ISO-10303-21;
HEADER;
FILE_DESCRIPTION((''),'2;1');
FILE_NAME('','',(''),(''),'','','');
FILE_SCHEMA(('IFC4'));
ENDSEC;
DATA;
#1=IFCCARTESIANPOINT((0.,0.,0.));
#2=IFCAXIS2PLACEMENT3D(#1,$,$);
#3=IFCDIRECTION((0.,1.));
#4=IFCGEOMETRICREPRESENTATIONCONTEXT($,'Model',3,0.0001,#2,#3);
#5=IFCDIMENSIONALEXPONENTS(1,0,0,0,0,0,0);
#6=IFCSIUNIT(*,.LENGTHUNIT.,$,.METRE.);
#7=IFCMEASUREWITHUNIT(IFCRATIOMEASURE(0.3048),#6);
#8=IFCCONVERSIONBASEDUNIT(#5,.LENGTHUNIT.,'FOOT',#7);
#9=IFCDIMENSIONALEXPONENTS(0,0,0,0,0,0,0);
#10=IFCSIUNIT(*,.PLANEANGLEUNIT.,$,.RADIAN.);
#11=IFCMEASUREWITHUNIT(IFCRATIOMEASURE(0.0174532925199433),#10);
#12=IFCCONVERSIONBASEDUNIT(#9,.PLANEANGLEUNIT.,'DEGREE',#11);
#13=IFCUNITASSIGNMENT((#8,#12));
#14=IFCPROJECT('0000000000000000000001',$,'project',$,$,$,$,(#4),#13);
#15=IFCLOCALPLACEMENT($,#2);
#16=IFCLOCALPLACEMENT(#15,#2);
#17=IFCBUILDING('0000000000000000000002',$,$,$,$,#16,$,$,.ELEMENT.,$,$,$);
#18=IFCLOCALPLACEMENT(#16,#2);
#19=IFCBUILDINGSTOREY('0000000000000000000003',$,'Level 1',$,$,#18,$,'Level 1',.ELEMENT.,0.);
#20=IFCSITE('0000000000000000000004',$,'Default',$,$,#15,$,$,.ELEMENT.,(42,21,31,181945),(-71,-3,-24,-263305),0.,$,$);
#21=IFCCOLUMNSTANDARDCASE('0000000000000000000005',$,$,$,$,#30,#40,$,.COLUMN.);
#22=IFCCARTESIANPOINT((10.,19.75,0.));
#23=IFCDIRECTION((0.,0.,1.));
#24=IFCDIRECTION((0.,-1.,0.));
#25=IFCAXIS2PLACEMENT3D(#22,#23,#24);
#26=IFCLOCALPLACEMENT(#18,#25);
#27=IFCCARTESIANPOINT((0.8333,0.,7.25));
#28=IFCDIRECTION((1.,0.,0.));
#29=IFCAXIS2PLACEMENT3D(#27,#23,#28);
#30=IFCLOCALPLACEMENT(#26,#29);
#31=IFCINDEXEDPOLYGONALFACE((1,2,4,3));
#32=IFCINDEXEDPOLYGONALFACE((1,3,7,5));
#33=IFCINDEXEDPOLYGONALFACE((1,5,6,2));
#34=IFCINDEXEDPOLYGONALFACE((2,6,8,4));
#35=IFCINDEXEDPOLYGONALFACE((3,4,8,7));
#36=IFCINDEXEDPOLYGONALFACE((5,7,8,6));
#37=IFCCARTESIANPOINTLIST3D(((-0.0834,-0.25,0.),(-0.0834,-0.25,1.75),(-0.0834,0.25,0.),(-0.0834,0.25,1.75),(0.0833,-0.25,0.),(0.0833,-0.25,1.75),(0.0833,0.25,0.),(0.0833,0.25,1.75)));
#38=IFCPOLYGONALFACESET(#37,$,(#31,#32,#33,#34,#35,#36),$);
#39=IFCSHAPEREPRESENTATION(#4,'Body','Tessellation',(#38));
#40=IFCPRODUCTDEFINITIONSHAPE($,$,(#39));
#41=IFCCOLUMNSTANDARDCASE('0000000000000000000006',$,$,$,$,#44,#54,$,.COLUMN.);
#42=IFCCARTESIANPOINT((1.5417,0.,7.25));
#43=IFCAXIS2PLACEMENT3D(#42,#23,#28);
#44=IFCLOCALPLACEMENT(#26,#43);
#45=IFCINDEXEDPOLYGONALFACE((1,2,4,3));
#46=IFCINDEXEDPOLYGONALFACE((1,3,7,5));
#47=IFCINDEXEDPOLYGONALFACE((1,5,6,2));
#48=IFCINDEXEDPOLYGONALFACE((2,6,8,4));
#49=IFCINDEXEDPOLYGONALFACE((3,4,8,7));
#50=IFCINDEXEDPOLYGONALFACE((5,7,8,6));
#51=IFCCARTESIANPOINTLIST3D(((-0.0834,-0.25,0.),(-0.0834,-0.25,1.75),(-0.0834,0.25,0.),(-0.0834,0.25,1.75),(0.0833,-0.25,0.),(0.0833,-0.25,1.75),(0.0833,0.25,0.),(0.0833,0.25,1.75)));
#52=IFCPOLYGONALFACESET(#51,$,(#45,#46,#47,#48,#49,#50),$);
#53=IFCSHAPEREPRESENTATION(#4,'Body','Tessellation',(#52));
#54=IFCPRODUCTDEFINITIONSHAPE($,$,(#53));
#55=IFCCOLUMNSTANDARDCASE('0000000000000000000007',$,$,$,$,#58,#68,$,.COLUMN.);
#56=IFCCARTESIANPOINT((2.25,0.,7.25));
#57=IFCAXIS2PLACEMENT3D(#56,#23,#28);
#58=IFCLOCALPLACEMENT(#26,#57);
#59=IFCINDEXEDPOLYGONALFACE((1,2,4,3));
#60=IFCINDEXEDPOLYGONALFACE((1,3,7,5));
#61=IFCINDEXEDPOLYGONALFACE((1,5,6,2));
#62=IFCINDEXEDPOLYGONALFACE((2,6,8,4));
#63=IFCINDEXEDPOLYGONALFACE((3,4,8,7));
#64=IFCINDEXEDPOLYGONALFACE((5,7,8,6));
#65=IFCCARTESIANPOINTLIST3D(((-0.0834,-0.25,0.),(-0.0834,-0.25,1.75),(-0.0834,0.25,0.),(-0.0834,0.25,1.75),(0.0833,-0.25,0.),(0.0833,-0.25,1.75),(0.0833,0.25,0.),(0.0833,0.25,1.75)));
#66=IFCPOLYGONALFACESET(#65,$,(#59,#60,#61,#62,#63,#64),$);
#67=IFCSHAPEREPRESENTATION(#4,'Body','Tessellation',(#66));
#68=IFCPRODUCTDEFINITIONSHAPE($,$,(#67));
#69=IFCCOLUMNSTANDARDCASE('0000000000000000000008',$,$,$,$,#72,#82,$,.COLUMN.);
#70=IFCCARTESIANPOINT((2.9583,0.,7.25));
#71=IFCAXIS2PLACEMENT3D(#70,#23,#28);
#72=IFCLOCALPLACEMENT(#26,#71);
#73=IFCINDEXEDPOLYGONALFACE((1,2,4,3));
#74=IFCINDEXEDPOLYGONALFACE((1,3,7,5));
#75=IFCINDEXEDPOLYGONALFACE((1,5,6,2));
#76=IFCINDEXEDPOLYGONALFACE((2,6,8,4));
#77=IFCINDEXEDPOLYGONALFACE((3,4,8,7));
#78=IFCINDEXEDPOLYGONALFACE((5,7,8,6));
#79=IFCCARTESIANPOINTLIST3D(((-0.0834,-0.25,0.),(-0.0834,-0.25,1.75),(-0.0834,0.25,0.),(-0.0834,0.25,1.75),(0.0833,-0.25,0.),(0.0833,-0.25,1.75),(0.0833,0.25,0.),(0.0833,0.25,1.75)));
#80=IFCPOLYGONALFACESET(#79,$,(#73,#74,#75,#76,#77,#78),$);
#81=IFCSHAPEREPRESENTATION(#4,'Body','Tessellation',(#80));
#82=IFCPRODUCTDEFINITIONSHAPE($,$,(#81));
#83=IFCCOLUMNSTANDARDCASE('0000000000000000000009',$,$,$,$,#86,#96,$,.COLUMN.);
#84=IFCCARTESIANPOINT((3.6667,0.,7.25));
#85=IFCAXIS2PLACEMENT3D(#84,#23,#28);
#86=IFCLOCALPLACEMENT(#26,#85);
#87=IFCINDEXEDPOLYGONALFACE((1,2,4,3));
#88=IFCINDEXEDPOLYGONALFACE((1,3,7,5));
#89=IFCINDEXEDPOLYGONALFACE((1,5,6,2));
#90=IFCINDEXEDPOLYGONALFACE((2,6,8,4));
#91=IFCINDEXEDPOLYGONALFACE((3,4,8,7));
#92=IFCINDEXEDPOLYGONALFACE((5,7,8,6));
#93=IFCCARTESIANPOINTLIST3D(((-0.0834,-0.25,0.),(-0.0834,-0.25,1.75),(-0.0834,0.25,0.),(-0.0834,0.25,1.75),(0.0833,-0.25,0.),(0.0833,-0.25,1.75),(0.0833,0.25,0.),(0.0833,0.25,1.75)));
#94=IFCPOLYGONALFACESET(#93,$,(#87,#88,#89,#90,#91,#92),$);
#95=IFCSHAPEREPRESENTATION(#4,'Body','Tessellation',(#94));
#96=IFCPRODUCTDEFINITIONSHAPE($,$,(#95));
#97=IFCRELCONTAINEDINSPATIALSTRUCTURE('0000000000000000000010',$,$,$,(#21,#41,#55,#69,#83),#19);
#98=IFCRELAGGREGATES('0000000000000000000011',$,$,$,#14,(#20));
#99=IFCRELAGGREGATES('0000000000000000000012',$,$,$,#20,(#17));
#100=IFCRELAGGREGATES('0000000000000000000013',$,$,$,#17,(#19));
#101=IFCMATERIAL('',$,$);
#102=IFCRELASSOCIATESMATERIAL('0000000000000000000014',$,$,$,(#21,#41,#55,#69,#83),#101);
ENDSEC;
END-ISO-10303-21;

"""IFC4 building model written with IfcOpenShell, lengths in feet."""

from ifc_helpers import new_model, entity, si_unit, converted_unit, direction, frame, origin, place, context, project, spatial, rectangle, extrude, material, element, save


model = new_model("IFC4")

# Units and contexts
model_context = context("Model", 3, precision=0.0001, world=origin(), true_north=direction((0.0, 1.0)))
ifc_project = project(units=[converted_unit("LENGTHUNIT", "FOOT", entity("IfcRatioMeasure", 0.3048), si_unit("LENGTHUNIT", "METRE"), dimensions=[1, 0, 0, 0, 0, 0, 0]), converted_unit("PLANEANGLEUNIT", "DEGREE", entity("IfcRatioMeasure", 0.0174532925199433), si_unit("PLANEANGLEUNIT", "RADIAN"), dimensions=[0, 0, 0, 0, 0, 0, 0])], contexts=[model_context])

# Site, building, storey
site_placement = place(None, origin())
site = spatial("IfcSite", under=ifc_project, at=site_placement, Name="Default", CompositionType="ELEMENT", RefLatitude=(42, 21, 31, 181945), RefLongitude=(-71, -3, -24, -263305), RefElevation=0.0)
building_placement = place(site_placement, origin())
building = spatial("IfcBuilding", under=site, at=building_placement, CompositionType="ELEMENT")
storey_placement = place(building_placement, origin())
storey = spatial("IfcBuildingStorey", under=building, at=storey_placement, Name="Level 1", LongName="Level 1", CompositionType="ELEMENT", Elevation=0.0)

# Columns
placement_1 = place(storey_placement, frame((10.0, 19.75, 0.0), z_axis=(0.0, 0.0, 1.0), x_axis=(0.0, -1.0, 0.0)))
ifc_material_1 = material(Name="")
for number, where, z_axis, x_axis in (
    (1, (0.8333, 0.0, 7.25), (0.0, 0.0, 1.0), (1.0, 0.0, 0.0)),
    (2, (1.5417, 0.0, 7.25), (0.0, 0.0, 1.0), (1.0, 0.0, 0.0)),
    (3, (2.25, 0.0, 7.25), (0.0, 0.0, 1.0), (1.0, 0.0, 0.0)),
    (4, (2.9583, 0.0, 7.25), (0.0, 0.0, 1.0), (1.0, 0.0, 0.0)),
    (5, (3.6667, 0.0, 7.25), (0.0, 0.0, 1.0), (1.0, 0.0, 0.0)),
):
    element("IfcColumnStandardCase", number, at=place(placement_1, frame(where, z_axis=z_axis, x_axis=x_axis)), inside=storey, material=ifc_material_1, PredefinedType="COLUMN", context=model_context, shape_type="SweptSolid", body=[
        extrude(rectangle(XDim=0.1667, YDim=0.5), origin(), (0.0, 0.0, 1.0), 1.75),
    ])

save(model, "model.ifc")
